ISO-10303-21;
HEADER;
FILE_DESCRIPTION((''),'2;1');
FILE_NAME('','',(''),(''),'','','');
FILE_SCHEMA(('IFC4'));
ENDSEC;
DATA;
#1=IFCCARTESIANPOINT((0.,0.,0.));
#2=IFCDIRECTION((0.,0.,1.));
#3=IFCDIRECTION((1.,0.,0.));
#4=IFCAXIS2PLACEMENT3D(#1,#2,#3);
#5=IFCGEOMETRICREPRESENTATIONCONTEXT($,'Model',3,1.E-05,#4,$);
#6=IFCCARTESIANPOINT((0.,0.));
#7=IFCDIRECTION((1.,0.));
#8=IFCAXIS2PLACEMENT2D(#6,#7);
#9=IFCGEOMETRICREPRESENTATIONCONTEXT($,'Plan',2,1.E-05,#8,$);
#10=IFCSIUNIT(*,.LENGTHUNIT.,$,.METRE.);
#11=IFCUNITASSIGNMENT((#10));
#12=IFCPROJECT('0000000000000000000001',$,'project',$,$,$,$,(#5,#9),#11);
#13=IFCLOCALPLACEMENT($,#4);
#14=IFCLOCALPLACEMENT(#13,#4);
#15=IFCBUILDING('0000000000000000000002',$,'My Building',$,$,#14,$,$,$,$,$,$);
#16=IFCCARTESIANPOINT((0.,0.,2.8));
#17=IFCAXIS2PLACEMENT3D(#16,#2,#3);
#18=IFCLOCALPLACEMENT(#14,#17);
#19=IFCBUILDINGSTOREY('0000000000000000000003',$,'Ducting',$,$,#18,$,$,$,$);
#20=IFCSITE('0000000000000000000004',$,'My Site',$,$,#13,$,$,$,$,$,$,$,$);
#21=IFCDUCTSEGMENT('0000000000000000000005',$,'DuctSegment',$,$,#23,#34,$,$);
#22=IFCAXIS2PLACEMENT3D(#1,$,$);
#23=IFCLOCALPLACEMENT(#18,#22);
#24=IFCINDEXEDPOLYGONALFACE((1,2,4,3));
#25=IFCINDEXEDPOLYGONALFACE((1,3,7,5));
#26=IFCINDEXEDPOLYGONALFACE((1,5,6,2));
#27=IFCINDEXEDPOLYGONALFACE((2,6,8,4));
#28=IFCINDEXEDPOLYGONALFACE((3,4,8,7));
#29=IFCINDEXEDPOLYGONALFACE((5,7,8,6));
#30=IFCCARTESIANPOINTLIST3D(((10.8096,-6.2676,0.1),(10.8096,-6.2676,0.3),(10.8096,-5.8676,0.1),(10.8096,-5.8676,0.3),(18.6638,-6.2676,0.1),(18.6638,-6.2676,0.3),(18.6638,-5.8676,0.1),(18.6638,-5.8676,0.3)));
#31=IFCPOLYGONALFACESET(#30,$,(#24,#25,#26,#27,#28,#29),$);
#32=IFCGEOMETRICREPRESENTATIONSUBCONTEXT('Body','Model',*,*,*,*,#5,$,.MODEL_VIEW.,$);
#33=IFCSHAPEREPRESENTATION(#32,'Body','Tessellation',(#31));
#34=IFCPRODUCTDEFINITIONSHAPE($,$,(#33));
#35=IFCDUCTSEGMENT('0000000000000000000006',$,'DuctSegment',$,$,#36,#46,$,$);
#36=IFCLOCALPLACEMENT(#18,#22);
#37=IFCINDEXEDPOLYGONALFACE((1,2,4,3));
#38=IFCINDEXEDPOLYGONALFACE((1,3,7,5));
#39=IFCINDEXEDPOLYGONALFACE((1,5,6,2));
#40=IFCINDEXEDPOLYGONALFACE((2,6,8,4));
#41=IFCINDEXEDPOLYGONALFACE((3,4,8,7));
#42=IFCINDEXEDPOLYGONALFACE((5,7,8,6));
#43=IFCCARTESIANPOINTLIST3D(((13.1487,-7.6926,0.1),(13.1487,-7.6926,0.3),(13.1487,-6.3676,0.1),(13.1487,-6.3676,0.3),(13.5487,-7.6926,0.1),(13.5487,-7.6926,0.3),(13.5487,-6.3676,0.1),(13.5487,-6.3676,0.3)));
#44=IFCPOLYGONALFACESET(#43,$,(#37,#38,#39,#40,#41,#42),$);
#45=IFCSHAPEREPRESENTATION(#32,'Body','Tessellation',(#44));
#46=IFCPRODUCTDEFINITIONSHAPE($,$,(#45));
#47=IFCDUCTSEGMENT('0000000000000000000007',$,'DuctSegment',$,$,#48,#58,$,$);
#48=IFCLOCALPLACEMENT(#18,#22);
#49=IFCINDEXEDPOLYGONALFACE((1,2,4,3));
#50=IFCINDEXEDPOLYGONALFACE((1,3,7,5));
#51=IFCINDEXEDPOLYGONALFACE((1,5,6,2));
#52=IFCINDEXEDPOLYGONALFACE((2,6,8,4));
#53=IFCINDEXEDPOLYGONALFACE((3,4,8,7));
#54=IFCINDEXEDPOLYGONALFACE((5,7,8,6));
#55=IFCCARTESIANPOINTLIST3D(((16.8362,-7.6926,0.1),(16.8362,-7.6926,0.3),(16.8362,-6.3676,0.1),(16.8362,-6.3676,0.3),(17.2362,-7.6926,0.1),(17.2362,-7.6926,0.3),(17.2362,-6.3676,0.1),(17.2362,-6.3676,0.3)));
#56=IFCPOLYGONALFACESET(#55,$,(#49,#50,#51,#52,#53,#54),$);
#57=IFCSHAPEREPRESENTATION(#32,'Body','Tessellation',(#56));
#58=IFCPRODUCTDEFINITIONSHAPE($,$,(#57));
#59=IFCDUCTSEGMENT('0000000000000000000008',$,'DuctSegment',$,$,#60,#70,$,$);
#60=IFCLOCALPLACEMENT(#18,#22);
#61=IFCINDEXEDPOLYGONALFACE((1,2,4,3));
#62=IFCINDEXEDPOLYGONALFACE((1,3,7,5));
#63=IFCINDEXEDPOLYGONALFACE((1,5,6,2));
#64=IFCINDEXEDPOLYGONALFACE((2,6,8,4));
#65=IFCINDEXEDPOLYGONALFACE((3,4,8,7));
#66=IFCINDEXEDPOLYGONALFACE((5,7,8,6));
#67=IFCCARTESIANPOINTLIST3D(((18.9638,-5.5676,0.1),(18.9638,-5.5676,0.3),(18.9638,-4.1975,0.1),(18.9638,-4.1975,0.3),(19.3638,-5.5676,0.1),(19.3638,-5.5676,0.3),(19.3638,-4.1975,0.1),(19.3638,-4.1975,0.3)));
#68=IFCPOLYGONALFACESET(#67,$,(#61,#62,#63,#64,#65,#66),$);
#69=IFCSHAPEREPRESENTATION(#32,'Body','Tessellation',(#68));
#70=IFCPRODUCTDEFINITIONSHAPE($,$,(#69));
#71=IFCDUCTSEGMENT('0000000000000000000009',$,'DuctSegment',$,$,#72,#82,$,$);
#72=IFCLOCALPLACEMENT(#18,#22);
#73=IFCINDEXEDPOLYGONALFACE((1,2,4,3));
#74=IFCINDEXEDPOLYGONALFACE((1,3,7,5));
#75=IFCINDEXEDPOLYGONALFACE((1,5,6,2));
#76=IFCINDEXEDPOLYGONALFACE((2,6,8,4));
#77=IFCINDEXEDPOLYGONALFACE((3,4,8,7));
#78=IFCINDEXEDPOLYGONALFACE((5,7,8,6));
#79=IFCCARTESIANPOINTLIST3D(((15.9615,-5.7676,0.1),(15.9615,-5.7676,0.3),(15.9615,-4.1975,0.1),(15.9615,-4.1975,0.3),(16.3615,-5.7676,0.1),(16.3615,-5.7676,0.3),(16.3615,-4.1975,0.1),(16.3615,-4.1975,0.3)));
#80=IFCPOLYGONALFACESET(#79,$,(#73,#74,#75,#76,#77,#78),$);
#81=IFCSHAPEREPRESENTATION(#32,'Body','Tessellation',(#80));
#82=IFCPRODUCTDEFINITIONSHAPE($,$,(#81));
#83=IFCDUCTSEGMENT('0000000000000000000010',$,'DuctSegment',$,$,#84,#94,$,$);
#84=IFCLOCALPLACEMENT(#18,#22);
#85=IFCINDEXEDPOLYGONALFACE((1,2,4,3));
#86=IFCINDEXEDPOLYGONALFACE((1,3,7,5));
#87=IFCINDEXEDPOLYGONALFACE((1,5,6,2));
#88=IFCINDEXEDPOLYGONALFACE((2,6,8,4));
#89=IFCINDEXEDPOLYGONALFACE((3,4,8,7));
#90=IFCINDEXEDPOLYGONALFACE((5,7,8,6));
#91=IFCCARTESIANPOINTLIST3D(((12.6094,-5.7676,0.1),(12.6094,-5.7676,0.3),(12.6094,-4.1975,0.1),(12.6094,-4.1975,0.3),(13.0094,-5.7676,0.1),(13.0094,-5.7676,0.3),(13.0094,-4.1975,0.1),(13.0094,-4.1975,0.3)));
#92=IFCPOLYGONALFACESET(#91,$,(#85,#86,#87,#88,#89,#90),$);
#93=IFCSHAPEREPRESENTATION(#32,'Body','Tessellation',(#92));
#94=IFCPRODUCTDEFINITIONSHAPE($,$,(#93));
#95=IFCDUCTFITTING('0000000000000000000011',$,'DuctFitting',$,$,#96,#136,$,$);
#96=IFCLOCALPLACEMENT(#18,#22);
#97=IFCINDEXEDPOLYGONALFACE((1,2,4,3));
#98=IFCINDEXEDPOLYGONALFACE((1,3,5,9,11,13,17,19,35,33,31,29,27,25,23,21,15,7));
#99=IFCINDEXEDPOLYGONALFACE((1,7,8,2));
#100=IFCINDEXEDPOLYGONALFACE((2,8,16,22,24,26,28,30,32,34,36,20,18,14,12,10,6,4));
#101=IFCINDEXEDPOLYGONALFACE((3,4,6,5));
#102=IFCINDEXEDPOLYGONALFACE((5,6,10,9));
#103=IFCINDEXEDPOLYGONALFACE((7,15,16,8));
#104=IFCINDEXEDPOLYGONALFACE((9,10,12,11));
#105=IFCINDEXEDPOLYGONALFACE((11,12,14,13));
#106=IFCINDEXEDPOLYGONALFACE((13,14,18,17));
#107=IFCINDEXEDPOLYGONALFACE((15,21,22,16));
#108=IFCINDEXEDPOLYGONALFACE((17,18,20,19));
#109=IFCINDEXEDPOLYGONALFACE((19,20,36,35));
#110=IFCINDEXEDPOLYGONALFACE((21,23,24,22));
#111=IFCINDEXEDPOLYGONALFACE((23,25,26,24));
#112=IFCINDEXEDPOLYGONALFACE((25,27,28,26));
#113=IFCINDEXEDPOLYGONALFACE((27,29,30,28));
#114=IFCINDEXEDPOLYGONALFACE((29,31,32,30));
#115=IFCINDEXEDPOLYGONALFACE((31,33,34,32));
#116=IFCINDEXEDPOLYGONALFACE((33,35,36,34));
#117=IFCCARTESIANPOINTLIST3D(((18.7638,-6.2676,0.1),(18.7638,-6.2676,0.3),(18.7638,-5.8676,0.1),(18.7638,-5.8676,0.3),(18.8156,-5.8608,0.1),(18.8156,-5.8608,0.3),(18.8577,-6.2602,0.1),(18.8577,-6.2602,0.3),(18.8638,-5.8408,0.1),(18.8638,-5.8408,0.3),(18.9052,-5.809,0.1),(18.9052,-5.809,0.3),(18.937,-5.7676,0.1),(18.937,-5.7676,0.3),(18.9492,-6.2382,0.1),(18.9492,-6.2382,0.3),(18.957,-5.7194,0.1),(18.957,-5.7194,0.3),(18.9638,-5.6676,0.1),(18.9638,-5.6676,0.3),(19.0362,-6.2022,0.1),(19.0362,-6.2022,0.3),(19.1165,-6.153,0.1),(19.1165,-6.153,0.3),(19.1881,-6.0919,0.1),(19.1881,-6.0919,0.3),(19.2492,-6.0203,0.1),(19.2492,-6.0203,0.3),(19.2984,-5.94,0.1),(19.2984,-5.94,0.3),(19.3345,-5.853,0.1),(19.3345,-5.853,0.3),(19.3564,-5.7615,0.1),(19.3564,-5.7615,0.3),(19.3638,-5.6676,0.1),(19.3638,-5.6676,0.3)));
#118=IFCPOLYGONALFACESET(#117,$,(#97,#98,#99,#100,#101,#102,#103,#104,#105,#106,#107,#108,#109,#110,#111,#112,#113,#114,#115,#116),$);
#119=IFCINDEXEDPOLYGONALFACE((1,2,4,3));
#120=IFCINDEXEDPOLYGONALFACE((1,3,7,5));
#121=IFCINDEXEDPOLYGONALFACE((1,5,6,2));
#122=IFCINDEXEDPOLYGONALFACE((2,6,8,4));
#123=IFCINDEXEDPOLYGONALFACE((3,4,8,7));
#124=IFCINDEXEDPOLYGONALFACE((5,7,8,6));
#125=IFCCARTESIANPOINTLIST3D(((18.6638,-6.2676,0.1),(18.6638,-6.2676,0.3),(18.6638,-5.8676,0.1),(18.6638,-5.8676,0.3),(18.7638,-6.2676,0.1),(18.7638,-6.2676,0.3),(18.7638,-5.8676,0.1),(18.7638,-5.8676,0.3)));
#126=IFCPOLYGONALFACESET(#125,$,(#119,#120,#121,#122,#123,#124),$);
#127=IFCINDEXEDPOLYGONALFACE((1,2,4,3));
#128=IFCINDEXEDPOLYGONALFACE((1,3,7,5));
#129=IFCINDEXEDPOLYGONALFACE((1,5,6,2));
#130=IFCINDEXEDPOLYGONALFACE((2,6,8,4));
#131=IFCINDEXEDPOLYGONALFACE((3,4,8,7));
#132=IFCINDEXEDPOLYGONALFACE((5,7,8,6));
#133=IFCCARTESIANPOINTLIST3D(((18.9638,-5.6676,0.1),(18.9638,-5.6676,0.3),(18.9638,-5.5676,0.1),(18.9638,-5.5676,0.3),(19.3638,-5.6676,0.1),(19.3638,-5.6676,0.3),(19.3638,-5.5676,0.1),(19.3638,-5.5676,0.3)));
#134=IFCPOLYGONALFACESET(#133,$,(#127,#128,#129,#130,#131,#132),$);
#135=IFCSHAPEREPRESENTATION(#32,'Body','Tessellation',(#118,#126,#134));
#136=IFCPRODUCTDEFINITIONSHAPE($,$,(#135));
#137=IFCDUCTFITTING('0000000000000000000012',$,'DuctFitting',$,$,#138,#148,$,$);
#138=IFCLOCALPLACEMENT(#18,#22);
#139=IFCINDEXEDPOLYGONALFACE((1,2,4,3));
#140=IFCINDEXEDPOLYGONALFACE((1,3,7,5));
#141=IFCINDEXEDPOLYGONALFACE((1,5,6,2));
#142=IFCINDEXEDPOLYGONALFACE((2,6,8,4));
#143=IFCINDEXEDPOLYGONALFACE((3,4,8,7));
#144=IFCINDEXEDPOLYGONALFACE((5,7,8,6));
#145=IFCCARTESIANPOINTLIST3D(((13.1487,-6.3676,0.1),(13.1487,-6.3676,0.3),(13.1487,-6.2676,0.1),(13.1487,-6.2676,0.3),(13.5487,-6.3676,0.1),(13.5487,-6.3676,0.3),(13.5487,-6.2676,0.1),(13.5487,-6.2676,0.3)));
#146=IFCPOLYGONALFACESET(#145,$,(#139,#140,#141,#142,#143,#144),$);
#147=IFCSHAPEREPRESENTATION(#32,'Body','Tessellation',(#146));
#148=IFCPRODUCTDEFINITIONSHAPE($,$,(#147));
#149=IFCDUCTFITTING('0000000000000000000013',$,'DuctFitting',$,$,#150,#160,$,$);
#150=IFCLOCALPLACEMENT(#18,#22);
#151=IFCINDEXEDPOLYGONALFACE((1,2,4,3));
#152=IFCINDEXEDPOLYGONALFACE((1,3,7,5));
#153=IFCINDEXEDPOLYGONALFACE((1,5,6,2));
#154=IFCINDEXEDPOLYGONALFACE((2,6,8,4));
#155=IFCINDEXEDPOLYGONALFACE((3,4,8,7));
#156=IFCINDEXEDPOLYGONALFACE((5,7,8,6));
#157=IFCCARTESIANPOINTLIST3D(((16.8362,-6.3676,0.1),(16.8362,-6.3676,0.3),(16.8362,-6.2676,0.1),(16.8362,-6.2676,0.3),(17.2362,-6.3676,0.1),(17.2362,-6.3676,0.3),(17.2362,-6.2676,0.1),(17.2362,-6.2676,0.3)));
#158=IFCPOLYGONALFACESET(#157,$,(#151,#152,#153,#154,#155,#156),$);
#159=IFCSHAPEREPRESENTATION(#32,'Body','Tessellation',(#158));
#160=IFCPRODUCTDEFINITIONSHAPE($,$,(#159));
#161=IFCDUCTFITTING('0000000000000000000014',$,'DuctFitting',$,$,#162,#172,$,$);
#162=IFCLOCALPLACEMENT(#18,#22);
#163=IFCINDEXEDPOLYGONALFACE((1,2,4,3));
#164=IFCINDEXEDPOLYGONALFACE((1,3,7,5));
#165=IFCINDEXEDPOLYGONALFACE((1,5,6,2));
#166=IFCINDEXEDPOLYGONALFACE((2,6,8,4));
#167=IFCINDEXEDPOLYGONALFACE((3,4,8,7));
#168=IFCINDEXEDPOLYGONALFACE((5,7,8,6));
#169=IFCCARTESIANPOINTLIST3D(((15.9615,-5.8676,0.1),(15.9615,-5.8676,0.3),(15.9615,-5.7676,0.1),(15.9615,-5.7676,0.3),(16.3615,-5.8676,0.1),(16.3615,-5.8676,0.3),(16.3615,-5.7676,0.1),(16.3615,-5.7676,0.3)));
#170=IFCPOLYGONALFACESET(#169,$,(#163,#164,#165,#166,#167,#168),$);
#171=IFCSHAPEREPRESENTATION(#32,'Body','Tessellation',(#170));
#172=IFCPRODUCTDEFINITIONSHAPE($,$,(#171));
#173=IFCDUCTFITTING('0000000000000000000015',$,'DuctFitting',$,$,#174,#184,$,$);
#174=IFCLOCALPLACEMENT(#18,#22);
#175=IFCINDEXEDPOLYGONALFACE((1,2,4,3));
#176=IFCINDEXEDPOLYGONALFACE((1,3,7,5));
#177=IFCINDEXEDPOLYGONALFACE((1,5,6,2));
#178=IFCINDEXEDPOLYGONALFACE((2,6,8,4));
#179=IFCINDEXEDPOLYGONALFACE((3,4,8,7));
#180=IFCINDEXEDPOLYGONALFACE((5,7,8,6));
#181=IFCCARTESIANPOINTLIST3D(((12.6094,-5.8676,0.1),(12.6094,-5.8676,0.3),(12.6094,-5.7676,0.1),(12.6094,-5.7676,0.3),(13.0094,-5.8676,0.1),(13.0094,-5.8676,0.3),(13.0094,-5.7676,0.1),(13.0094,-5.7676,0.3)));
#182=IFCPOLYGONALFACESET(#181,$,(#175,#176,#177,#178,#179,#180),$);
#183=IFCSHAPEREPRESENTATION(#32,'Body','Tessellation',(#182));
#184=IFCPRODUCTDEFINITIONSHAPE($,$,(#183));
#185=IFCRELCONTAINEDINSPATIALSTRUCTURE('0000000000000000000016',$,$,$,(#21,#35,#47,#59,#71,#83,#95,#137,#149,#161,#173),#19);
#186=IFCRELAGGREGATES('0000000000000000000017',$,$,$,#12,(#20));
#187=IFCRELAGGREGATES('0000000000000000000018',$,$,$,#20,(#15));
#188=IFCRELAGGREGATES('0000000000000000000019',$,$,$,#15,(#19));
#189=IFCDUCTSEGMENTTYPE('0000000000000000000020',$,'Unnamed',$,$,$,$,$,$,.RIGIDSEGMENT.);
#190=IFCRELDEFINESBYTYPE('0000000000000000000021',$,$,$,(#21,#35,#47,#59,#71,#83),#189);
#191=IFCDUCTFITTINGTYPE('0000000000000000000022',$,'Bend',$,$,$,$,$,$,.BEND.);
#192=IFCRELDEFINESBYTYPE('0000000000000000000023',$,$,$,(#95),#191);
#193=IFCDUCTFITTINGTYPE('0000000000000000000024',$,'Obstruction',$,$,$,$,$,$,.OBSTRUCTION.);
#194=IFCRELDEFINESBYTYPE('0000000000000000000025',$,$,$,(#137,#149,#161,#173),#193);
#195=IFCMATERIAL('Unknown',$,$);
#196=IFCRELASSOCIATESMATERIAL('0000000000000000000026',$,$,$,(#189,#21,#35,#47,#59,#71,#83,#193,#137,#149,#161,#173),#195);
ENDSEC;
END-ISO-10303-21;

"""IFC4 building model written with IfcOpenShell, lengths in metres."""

from ifc_helpers import new_model, si_unit, frame, origin_with_axes, origin_2d_with_axis, place, context, subcontext, project, spatial, line, arc, indexed_curve, rectangle, outline, extrude, source, transform, mapped, material, material_profile, profile_set, profile_usage, type_object, type_shapes, element, save


model = new_model("IFC4")

# Units and contexts
model_context = context("Model", 3, precision=1e-05, world=origin_with_axes())
plan_context = context("Plan", 2, precision=1e-05, world=origin_2d_with_axis())
body_context = subcontext(model_context, "Body", "Model", "MODEL_VIEW")
ifc_project = project(units=[si_unit("LENGTHUNIT", "METRE")], contexts=[model_context, plan_context])

# Site, building, storey
site_placement = place(None, origin_with_axes())
site = spatial("IfcSite", under=ifc_project, at=site_placement, Name="My Site")
building_placement = place(site_placement, origin_with_axes())
building = spatial("IfcBuilding", under=site, at=building_placement, Name="My Building")
storey_placement = place(building_placement, frame((0.0, 0.0, 2.8), z_axis=(0.0, 0.0, 1.0), x_axis=(1.0, 0.0, 0.0)))
storey = spatial("IfcBuildingStorey", under=building, at=storey_placement, Name="Ducting")

# Duct segments
ifc_material = material(Name="Unknown")
ifc_material_profile_1 = material_profile(ifc_material, rectangle(XDim=0.4, YDim=0.2))
ifc_profile_set_1 = profile_set([ifc_material_profile_1])
ifc_profile_usage_1 = profile_usage(ifc_profile_set_1, cardinal=9)
duct_segment_type = type_object("IfcDuctSegmentType", Name="Unnamed", PredefinedType="RIGIDSEGMENT", material=ifc_profile_set_1)
duct_segment_1_placement = place(storey_placement, frame((10.8096, -6.2676, 0.3), z_axis=(1.0, 0.0, 0.0), x_axis=(0.0, 1.0, 0.0)))
element("IfcDuctSegment", 1, at=duct_segment_1_placement, inside=storey, type_object=duct_segment_type, material=ifc_profile_usage_1, Name="DuctSegment", context=body_context, shape_type="SweptSolid", body=[
    extrude(rectangle(XDim=0.4, YDim=0.2), frame((0.2, -0.1, 0.0), z_axis=(0.0, 0.0, 1.0), x_axis=(1.0, 0.0, 0.0)), (0.0, 0.0, 1.0), 7.8542),
])
ifc_profile_usage_2 = profile_usage(ifc_profile_set_1, cardinal=5)
duct_segment_2_placement = place(storey_placement, frame((13.3487, -6.3676, 0.2), z_axis=(0.0, -1.0, 0.0), x_axis=(1.0, 0.0, 0.0)))
element("IfcDuctSegment", 2, at=duct_segment_2_placement, inside=storey, type_object=duct_segment_type, material=ifc_profile_usage_2, Name="DuctSegment", context=body_context, shape_type="SweptSolid", body=[
    extrude(rectangle(XDim=0.4, YDim=0.2), origin_with_axes(), (0.0, 0.0, 1.0), 1.325),
])
ifc_profile_usage_3 = profile_usage(ifc_profile_set_1, cardinal=5)
duct_segment_3_placement = place(storey_placement, frame((17.0362, -6.3676, 0.2), z_axis=(0.0, -1.0, 0.0), x_axis=(1.0, 0.0, 0.0)))
element("IfcDuctSegment", 3, at=duct_segment_3_placement, inside=storey, type_object=duct_segment_type, material=ifc_profile_usage_3, Name="DuctSegment", context=body_context, shape_type="SweptSolid", body=[
    extrude(rectangle(XDim=0.4, YDim=0.2), origin_with_axes(), (0.0, 0.0, 1.0), 1.325),
])
ifc_profile_usage_4 = profile_usage(ifc_profile_set_1, cardinal=5)
duct_segment_4_placement = place(storey_placement, frame((19.1638, -5.5676, 0.2), z_axis=(0.0, 1.0, 0.0), x_axis=(-1.0, 0.0, 0.0)))
element("IfcDuctSegment", 4, at=duct_segment_4_placement, inside=storey, type_object=duct_segment_type, material=ifc_profile_usage_4, Name="DuctSegment", context=body_context, shape_type="SweptSolid", body=[
    extrude(rectangle(XDim=0.4, YDim=0.2), origin_with_axes(), (0.0, 0.0, 1.0), 1.3701),
])
ifc_profile_usage_5 = profile_usage(ifc_profile_set_1, cardinal=5)
duct_segment_5_placement = place(storey_placement, frame((16.1615, -5.7676, 0.2), z_axis=(0.0, 1.0, 0.0), x_axis=(-1.0, 0.0, 0.0)))
element("IfcDuctSegment", 5, at=duct_segment_5_placement, inside=storey, type_object=duct_segment_type, material=ifc_profile_usage_5, Name="DuctSegment", context=body_context, shape_type="SweptSolid", body=[
    extrude(rectangle(XDim=0.4, YDim=0.2), origin_with_axes(), (0.0, 0.0, 1.0), 1.5701),
])
ifc_profile_usage_6 = profile_usage(ifc_profile_set_1, cardinal=5)
duct_segment_6_placement = place(storey_placement, frame((12.8094, -5.7676, 0.2), z_axis=(0.0, 1.0, 0.0), x_axis=(-1.0, 0.0, 0.0)))
element("IfcDuctSegment", 6, at=duct_segment_6_placement, inside=storey, type_object=duct_segment_type, material=ifc_profile_usage_6, Name="DuctSegment", context=body_context, shape_type="SweptSolid", body=[
    extrude(rectangle(XDim=0.4, YDim=0.2), origin_with_axes(), (0.0, 0.0, 1.0), 1.5701),
])

# Duct fittings
duct_fitting_type_1 = type_object("IfcDuctFittingType", Name="Bend", PredefinedType="BEND")
shared_shape = source(origin_with_axes(), body_context, "Body", "SweptSolid", [
    extrude(outline(indexed_curve([(0.2, 0.0), (0.2586, 0.1414), (0.4, 0.2), (0.4, 0.6), (-0.0243, 0.4243), (-0.2, 0.0)], segments=[arc(1, 2, 3), line(3, 4), arc(4, 5, 6), line(6, 1)])), frame((0.0, -0.1, 0.1), z_axis=(0.0, -1.0, 0.0), x_axis=(1.0, 0.0, 0.0)), (0.0, 0.0, -1.0), 0.2),
    extrude(rectangle(XDim=0.4, YDim=0.2), origin_with_axes(), (0.0, 0.0, 1.0), 0.1),
    extrude(rectangle(XDim=0.4, YDim=0.2), frame((0.4, 0.0, 0.5), z_axis=(1.0, 0.0, 0.0), x_axis=(0.0, 0.0, 1.0)), (0.0, 0.0, 1.0), 0.1),
])
type_shapes(duct_fitting_type_1, [shared_shape])
duct_fitting_1_placement = place(storey_placement, frame((18.6638, -6.0676, 0.2), z_axis=(1.0, 0.0, 0.0), x_axis=(0.0, 1.0, 0.0)))
element("IfcDuctFitting", 7, at=duct_fitting_1_placement, inside=storey, type_object=duct_fitting_type_1, Name="DuctFitting", context=body_context, shape_type="MappedRepresentation", body=[
    mapped(shared_shape, transform((0.0, 0.0, 0.0), x_axis=(1.0, 0.0, 0.0), y_axis=(0.0, 1.0, 0.0), z_axis=(0.0, 0.0, 1.0), scale=1.0)),
])
ifc_material_profile_2 = material_profile(ifc_material, rectangle(XDim=0.4, YDim=0.2))
ifc_profile_set_2 = profile_set([ifc_material_profile_2])
ifc_profile_usage_7 = profile_usage(ifc_profile_set_2, cardinal=5)
duct_fitting_type_2 = type_object("IfcDuctFittingType", Name="Obstruction", PredefinedType="OBSTRUCTION", material=ifc_profile_set_2)
duct_fitting_2_placement = place(storey_placement, frame((13.3487, -6.2676, 0.2), z_axis=(0.0, -1.0, 0.0), x_axis=(1.0, 0.0, 0.0)))
element("IfcDuctFitting", 8, at=duct_fitting_2_placement, inside=storey, type_object=duct_fitting_type_2, material=ifc_profile_usage_7, Name="DuctFitting", context=body_context, shape_type="SweptSolid", body=[
    extrude(rectangle(XDim=0.4, YDim=0.2), origin_with_axes(), (0.0, 0.0, 1.0), 0.1),
])
ifc_profile_usage_8 = profile_usage(ifc_profile_set_2, cardinal=5)
duct_fitting_3_placement = place(storey_placement, frame((17.0362, -6.2676, 0.2), z_axis=(0.0, -1.0, 0.0), x_axis=(1.0, 0.0, 0.0)))
element("IfcDuctFitting", 9, at=duct_fitting_3_placement, inside=storey, type_object=duct_fitting_type_2, material=ifc_profile_usage_8, Name="DuctFitting", context=body_context, shape_type="SweptSolid", body=[
    extrude(rectangle(XDim=0.4, YDim=0.2), origin_with_axes(), (0.0, 0.0, 1.0), 0.1),
])
ifc_profile_usage_9 = profile_usage(ifc_profile_set_2, cardinal=5)
duct_fitting_4_placement = place(storey_placement, frame((16.1615, -5.8676, 0.2), z_axis=(0.0, 1.0, 0.0), x_axis=(-1.0, 0.0, 0.0)))
element("IfcDuctFitting", 10, at=duct_fitting_4_placement, inside=storey, type_object=duct_fitting_type_2, material=ifc_profile_usage_9, Name="DuctFitting", context=body_context, shape_type="SweptSolid", body=[
    extrude(rectangle(XDim=0.4, YDim=0.2), origin_with_axes(), (0.0, 0.0, 1.0), 0.1),
])
ifc_profile_usage_10 = profile_usage(ifc_profile_set_2, cardinal=5)
duct_fitting_5_placement = place(storey_placement, frame((12.8094, -5.8676, 0.2), z_axis=(0.0, 1.0, 0.0), x_axis=(-1.0, 0.0, 0.0)))
element("IfcDuctFitting", 11, at=duct_fitting_5_placement, inside=storey, type_object=duct_fitting_type_2, material=ifc_profile_usage_10, Name="DuctFitting", context=body_context, shape_type="SweptSolid", body=[
    extrude(rectangle(XDim=0.4, YDim=0.2), origin_with_axes(), (0.0, 0.0, 1.0), 0.1),
])

save(model, "model.ifc")
